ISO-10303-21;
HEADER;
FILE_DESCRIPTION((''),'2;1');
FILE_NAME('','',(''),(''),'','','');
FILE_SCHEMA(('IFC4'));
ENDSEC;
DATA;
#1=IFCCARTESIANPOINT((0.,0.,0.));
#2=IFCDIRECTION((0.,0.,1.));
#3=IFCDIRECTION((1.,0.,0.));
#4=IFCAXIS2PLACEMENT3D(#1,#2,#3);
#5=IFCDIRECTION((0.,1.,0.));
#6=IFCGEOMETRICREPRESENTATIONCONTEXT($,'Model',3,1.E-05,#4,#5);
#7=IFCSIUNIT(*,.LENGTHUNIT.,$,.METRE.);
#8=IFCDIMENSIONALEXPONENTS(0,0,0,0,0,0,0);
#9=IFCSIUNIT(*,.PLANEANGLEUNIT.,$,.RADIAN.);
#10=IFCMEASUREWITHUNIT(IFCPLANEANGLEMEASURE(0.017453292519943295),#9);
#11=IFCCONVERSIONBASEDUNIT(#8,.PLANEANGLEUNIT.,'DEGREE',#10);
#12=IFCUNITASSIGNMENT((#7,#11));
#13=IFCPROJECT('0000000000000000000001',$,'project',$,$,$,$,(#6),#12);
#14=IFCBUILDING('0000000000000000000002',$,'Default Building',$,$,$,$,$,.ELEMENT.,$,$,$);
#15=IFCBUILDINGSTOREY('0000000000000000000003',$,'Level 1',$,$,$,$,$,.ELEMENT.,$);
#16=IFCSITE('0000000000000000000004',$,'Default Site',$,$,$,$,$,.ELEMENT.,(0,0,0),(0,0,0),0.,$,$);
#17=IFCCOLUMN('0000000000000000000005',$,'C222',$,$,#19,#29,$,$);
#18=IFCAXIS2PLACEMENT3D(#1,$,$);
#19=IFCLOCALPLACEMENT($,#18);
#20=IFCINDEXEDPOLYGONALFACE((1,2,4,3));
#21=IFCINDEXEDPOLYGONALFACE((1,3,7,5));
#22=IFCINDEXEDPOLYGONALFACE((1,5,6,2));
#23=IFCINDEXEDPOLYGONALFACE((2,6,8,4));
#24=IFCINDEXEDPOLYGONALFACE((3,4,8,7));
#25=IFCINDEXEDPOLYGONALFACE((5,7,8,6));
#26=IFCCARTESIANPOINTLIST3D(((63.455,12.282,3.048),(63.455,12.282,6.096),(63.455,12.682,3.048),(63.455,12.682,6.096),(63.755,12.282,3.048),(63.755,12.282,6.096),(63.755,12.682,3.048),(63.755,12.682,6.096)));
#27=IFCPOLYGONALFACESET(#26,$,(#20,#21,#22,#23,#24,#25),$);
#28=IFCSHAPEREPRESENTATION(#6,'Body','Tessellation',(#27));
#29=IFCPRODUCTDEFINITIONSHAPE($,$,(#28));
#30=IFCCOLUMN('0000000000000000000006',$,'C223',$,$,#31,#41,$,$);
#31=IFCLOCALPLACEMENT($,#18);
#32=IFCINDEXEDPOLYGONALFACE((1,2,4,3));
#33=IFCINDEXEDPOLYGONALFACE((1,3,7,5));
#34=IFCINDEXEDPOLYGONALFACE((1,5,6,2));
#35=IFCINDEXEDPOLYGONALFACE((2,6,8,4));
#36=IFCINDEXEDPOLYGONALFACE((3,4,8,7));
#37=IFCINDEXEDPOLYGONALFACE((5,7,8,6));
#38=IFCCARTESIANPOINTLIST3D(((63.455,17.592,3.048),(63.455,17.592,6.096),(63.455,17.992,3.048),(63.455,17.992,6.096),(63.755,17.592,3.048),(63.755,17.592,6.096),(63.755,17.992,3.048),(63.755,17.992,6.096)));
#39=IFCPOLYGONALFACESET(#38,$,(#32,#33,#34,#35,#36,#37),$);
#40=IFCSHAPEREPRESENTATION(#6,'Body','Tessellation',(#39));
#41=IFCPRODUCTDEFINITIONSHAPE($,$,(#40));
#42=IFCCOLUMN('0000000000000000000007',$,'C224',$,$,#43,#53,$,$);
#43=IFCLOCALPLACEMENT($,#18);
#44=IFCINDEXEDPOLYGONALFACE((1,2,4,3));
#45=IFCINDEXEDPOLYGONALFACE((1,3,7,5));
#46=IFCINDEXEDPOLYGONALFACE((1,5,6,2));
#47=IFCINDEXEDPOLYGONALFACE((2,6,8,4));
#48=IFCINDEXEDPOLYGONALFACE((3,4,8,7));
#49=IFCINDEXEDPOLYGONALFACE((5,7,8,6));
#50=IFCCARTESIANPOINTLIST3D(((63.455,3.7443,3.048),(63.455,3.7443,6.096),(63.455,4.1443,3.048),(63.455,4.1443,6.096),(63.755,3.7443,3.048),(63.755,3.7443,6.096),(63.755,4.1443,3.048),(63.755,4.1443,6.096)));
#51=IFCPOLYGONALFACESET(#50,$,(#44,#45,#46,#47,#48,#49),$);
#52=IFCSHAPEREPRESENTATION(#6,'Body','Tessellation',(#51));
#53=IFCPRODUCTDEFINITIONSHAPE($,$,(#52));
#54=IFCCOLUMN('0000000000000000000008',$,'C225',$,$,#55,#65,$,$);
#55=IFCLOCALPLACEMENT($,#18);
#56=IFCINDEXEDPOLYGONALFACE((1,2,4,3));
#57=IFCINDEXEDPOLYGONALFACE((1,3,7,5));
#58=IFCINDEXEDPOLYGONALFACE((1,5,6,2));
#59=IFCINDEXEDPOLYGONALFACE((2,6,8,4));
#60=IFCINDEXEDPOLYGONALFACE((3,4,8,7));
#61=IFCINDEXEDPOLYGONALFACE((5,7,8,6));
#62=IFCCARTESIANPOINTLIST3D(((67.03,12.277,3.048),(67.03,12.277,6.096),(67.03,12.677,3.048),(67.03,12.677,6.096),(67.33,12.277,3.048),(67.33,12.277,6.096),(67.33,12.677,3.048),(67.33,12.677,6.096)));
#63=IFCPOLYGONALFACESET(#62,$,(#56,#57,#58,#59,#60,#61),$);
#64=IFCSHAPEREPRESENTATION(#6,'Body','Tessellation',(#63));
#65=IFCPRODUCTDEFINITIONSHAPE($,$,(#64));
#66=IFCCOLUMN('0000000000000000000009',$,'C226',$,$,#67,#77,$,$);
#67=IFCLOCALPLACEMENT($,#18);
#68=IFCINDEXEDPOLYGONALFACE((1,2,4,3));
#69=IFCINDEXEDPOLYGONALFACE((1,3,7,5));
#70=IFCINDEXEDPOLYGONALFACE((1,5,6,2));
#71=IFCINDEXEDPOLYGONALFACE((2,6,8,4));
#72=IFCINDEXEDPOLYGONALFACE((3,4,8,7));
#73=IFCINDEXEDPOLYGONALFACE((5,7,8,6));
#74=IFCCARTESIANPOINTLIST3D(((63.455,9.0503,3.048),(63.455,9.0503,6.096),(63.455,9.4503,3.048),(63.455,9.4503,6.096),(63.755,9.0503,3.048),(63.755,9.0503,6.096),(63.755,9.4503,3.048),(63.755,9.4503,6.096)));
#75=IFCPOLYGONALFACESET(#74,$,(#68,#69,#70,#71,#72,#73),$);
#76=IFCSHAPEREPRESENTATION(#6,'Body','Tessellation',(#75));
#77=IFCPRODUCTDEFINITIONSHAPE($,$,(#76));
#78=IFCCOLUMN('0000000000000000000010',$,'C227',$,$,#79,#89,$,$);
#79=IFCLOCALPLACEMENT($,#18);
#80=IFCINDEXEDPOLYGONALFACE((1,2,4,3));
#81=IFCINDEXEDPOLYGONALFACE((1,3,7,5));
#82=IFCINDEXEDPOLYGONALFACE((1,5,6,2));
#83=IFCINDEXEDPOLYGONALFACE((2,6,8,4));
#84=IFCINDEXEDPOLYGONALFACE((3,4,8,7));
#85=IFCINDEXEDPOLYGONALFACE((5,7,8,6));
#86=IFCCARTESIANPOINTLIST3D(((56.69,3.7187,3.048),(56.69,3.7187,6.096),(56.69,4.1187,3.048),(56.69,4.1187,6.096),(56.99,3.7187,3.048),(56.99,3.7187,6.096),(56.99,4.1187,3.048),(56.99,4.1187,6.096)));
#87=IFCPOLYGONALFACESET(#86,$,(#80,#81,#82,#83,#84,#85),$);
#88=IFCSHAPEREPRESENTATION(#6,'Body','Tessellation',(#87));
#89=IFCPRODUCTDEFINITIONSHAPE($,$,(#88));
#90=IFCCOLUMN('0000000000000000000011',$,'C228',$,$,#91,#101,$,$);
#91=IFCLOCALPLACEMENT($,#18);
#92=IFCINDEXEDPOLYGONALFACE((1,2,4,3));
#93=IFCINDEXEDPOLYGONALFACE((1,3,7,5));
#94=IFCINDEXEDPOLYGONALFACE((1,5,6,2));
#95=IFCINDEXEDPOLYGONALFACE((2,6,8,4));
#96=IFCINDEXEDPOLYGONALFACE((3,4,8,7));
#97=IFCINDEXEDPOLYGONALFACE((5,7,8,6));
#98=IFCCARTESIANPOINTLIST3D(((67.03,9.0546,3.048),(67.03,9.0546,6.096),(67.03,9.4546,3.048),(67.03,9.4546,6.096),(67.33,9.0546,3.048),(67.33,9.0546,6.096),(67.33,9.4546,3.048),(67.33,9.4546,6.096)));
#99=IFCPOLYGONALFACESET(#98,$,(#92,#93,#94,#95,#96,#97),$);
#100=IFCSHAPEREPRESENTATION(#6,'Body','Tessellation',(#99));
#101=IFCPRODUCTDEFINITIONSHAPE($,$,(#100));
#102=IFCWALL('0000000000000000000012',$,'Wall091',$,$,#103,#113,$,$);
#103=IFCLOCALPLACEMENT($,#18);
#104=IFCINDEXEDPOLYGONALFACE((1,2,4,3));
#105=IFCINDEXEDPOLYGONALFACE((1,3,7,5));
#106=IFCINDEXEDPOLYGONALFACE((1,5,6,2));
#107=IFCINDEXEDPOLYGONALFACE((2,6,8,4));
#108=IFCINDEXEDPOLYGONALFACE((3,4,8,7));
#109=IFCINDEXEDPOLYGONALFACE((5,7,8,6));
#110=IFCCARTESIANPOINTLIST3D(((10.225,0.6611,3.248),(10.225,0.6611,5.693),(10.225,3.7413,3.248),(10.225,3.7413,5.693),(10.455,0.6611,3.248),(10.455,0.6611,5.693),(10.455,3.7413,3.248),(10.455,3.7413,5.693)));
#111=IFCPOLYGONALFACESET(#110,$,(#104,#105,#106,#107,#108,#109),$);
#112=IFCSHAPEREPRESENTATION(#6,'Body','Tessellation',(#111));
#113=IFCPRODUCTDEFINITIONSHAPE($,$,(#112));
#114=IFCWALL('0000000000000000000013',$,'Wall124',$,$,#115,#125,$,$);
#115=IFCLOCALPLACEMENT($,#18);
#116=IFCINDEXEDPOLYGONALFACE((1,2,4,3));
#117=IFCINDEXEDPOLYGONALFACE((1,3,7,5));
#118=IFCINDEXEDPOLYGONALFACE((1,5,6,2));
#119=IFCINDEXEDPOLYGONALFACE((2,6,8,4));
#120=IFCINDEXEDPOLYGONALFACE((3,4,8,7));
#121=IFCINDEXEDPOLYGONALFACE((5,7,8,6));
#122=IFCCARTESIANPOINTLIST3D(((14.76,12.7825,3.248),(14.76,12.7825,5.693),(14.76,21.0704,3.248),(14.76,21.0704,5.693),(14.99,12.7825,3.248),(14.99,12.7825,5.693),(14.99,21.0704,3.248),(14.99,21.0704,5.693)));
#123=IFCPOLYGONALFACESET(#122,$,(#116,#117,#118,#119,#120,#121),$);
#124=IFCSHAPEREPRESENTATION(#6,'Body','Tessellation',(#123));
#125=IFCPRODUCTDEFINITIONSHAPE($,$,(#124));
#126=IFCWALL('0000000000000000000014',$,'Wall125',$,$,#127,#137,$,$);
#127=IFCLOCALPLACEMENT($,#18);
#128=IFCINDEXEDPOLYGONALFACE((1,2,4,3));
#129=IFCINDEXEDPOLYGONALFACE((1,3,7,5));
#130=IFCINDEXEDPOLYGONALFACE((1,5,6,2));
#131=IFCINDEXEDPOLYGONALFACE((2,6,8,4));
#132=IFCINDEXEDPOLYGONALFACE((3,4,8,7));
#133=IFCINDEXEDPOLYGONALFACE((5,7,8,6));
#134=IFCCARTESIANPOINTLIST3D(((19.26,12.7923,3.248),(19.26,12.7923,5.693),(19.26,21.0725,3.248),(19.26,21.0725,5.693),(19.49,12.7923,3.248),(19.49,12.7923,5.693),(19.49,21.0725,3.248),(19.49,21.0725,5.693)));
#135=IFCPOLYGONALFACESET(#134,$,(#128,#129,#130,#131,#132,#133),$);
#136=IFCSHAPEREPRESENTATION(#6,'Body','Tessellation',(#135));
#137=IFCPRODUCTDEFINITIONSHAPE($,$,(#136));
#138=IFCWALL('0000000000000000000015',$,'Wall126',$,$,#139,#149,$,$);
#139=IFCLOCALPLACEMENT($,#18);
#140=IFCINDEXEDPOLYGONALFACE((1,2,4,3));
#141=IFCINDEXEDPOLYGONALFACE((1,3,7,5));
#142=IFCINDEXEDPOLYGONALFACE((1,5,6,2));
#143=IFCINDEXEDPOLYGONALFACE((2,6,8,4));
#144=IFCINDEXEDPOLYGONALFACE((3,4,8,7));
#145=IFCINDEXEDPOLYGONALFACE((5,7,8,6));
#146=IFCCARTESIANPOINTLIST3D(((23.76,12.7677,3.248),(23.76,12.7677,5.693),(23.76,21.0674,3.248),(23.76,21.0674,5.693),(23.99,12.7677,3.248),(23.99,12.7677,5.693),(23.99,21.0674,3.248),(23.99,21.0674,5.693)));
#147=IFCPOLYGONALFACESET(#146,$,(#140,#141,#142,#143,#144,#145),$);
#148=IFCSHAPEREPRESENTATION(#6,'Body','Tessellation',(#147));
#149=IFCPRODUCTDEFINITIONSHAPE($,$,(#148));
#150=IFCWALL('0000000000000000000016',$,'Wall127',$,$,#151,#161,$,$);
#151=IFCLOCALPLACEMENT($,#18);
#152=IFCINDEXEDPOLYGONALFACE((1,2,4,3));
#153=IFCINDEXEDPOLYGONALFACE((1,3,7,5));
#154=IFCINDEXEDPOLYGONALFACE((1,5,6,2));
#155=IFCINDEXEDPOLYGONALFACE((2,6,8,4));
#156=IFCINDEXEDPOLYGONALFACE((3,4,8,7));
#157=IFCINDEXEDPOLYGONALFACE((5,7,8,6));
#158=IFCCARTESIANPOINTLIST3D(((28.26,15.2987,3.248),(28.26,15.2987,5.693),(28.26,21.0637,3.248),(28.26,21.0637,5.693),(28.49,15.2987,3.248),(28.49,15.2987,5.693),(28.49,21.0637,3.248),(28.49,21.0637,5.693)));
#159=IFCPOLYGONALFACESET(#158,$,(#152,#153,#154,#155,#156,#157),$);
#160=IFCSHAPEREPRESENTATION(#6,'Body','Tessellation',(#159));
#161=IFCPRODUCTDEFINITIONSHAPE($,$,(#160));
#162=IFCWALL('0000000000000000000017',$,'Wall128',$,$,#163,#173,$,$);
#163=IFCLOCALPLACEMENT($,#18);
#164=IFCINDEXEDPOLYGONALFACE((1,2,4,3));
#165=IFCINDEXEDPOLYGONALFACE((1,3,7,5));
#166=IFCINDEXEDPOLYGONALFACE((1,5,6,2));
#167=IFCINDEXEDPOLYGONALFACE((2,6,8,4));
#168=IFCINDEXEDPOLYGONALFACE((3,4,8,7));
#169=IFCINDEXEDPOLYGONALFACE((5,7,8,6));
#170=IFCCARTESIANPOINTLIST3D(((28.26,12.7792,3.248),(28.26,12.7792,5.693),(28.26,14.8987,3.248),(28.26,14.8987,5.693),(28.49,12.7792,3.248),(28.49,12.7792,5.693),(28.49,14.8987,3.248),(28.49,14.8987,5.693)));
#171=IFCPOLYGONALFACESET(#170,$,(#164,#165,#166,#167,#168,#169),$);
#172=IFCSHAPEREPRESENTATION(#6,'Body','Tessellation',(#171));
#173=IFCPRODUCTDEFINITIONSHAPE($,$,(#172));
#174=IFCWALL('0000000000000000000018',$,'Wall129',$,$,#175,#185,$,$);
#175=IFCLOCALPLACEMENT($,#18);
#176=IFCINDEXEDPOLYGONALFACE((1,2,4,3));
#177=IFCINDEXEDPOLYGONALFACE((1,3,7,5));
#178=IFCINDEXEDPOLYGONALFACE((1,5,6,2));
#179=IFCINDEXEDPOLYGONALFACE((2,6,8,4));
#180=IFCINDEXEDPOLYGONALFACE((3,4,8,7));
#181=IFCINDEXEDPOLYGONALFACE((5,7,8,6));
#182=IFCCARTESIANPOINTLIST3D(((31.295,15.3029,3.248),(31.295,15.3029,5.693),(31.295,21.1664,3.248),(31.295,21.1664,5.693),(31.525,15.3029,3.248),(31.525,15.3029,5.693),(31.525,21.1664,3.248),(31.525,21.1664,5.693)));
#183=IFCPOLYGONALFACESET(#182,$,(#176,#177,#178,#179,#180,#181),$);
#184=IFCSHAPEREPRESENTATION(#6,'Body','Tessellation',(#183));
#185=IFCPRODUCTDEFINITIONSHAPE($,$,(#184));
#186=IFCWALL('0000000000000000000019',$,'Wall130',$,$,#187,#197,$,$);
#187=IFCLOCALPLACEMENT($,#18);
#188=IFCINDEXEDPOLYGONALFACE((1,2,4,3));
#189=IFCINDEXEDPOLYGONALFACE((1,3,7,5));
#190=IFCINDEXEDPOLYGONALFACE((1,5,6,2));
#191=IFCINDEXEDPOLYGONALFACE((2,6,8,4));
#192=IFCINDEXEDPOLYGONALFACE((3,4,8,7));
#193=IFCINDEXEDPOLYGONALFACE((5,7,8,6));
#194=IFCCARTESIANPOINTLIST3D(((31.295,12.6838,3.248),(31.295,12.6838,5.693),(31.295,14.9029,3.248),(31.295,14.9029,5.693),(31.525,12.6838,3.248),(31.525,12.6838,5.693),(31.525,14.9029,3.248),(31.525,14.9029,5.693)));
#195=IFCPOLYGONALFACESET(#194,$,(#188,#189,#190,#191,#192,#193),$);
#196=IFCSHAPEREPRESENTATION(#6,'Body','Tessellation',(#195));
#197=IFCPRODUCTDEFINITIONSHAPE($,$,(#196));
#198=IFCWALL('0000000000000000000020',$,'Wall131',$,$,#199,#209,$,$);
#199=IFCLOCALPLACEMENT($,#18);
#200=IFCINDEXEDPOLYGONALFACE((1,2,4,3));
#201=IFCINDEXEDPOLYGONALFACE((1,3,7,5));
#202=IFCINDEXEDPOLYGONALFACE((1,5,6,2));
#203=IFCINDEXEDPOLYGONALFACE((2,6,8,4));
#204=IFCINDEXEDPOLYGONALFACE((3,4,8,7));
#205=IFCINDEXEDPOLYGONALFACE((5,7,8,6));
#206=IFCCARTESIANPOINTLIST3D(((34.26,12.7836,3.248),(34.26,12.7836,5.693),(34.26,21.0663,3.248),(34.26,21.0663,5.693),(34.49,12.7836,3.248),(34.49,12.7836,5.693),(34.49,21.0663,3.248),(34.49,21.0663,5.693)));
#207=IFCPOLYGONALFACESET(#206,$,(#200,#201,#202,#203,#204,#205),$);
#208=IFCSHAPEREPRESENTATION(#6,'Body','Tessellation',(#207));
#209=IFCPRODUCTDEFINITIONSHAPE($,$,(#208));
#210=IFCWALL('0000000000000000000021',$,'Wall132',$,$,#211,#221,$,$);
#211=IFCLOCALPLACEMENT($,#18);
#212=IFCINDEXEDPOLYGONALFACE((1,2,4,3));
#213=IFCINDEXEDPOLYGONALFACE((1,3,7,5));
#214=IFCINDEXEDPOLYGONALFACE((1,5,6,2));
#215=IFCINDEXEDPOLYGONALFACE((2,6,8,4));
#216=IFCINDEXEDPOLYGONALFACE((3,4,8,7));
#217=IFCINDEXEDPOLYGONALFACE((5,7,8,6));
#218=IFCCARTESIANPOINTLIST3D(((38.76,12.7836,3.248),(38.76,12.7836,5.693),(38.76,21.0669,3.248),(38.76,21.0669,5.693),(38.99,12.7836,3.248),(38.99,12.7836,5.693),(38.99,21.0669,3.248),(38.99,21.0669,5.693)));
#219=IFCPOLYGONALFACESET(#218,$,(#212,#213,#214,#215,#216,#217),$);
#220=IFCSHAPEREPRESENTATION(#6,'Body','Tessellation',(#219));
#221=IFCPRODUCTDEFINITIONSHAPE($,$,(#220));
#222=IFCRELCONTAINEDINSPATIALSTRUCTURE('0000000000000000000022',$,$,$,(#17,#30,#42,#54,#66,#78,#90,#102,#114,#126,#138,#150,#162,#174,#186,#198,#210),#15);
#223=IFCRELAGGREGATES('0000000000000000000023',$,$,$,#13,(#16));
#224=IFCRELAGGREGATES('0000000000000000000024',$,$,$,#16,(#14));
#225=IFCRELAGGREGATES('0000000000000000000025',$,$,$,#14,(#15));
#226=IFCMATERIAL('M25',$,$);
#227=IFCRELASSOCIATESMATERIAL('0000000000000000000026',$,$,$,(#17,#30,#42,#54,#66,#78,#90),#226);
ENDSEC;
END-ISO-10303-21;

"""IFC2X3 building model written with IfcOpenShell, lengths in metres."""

from ifc_helpers import new_model, entity, si_unit, converted_unit, direction, frame, frame_2d, origin_with_axes, place, context, project, spatial, rectangle, extrude, material, element, save


model = new_model("IFC2X3")

# Units and contexts
model_context = context("Model", 3, precision=1e-05, world=origin_with_axes(), true_north=direction((0.0, 1.0, 0.0)))
ifc_project = project(units=[si_unit("LENGTHUNIT", "METRE"), converted_unit("PLANEANGLEUNIT", "DEGREE", entity("IfcPlaneAngleMeasure", 0.017453292519943295), si_unit("PLANEANGLEUNIT", "RADIAN"), dimensions=[0, 0, 0, 0, 0, 0, 0])], contexts=[model_context])

# Site, building, storey
site = spatial("IfcSite", under=ifc_project, Name="Default Site", CompositionType="ELEMENT", RefLatitude=(0, 0, 0), RefLongitude=(0, 0, 0), RefElevation=0.0)
building = spatial("IfcBuilding", under=site, Name="Default Building", CompositionType="ELEMENT")
storey = spatial("IfcBuildingStorey", under=building, Name="Level 1", CompositionType="ELEMENT")

# Columns
ifc_material = material(Name="M25")
placement = place(None, origin_with_axes())
element("IfcColumn", 1, at=placement, inside=storey, material=ifc_material, Name="C222", context=model_context, shape_type="SweptSolid", body=[
    extrude(rectangle(XDim=0.3, YDim=0.4, at=frame_2d((0.0, 0.0), x_axis=(1.0, 0.0, 0.0))), frame((63.605, 12.482, 3.048), z_axis=(0.0, 0.0, 1.0), x_axis=(1.0, 0.0, 0.0)), (0.0, 0.0, 1.0), 3.048),
])
element("IfcColumn", 2, at=placement, inside=storey, material=ifc_material, Name="C223", context=model_context, shape_type="SweptSolid", body=[
    extrude(rectangle(XDim=0.3, YDim=0.4, at=frame_2d((0.0, 0.0), x_axis=(1.0, 0.0, 0.0))), frame((63.605, 17.792, 3.048), z_axis=(0.0, 0.0, 1.0), x_axis=(1.0, 0.0, 0.0)), (0.0, 0.0, 1.0), 3.048),
])
element("IfcColumn", 3, at=placement, inside=storey, material=ifc_material, Name="C224", context=model_context, shape_type="SweptSolid", body=[
    extrude(rectangle(XDim=0.3, YDim=0.4, at=frame_2d((0.0, 0.0), x_axis=(1.0, 0.0, 0.0))), frame((63.605, 3.9443, 3.048), z_axis=(0.0, 0.0, 1.0), x_axis=(1.0, 0.0, 0.0)), (0.0, 0.0, 1.0), 3.048),
])
element("IfcColumn", 4, at=placement, inside=storey, material=ifc_material, Name="C225", context=model_context, shape_type="SweptSolid", body=[
    extrude(rectangle(XDim=0.3, YDim=0.4, at=frame_2d((0.0, 0.0), x_axis=(1.0, 0.0, 0.0))), frame((67.18, 12.477, 3.048), z_axis=(0.0, 0.0, 1.0), x_axis=(1.0, 0.0, 0.0)), (0.0, 0.0, 1.0), 3.048),
])
element("IfcColumn", 5, at=placement, inside=storey, material=ifc_material, Name="C226", context=model_context, shape_type="SweptSolid", body=[
    extrude(rectangle(XDim=0.3, YDim=0.4, at=frame_2d((0.0, 0.0), x_axis=(1.0, 0.0, 0.0))), frame((63.605, 9.2503, 3.048), z_axis=(0.0, 0.0, 1.0), x_axis=(1.0, 0.0, 0.0)), (0.0, 0.0, 1.0), 3.048),
])
element("IfcColumn", 6, at=placement, inside=storey, material=ifc_material, Name="C227", context=model_context, shape_type="SweptSolid", body=[
    extrude(rectangle(XDim=0.3, YDim=0.4, at=frame_2d((0.0, 0.0), x_axis=(1.0, 0.0, 0.0))), frame((56.84, 3.9187, 3.048), z_axis=(0.0, 0.0, 1.0), x_axis=(1.0, 0.0, 0.0)), (0.0, 0.0, 1.0), 3.048),
])
element("IfcColumn", 7, at=placement, inside=storey, material=ifc_material, Name="C228", context=model_context, shape_type="SweptSolid", body=[
    extrude(rectangle(XDim=0.3, YDim=0.4, at=frame_2d((0.0, 0.0), x_axis=(1.0, 0.0, 0.0))), frame((67.18, 9.2546, 3.048), z_axis=(0.0, 0.0, 1.0), x_axis=(1.0, 0.0, 0.0)), (0.0, 0.0, 1.0), 3.048),
])

# Walls
element("IfcWall", 8, at=placement, inside=storey, Name="Wall091", context=model_context, shape_type="SweptSolid", body=[
    extrude(rectangle(XDim=3.0802, YDim=0.23, at=frame_2d((0.0, 0.0), x_axis=(0.0, -1.0, 0.0))), frame((10.34, 2.2012, 3.248), z_axis=(0.0, 0.0, 1.0), x_axis=(1.0, 0.0, 0.0)), (0.0, 0.0, 1.0), 2.445),
])
element("IfcWall", 9, at=placement, inside=storey, Name="Wall124", context=model_context, shape_type="SweptSolid", body=[
    extrude(rectangle(XDim=8.2879, YDim=0.23, at=frame_2d((0.0, 0.0), x_axis=(0.0, -1.0, 0.0))), frame((14.875, 16.9264, 3.248), z_axis=(0.0, 0.0, 1.0), x_axis=(1.0, 0.0, 0.0)), (0.0, 0.0, 1.0), 2.445),
])
element("IfcWall", 10, at=placement, inside=storey, Name="Wall125", context=model_context, shape_type="SweptSolid", body=[
    extrude(rectangle(XDim=8.2802, YDim=0.23, at=frame_2d((0.0, 0.0), x_axis=(0.0, -1.0, 0.0))), frame((19.375, 16.9324, 3.248), z_axis=(0.0, 0.0, 1.0), x_axis=(1.0, 0.0, 0.0)), (0.0, 0.0, 1.0), 2.445),
])
element("IfcWall", 11, at=placement, inside=storey, Name="Wall126", context=model_context, shape_type="SweptSolid", body=[
    extrude(rectangle(XDim=8.2997, YDim=0.23, at=frame_2d((0.0, 0.0), x_axis=(0.0, -1.0, 0.0))), frame((23.875, 16.9175, 3.248), z_axis=(0.0, 0.0, 1.0), x_axis=(1.0, 0.0, 0.0)), (0.0, 0.0, 1.0), 2.445),
])
element("IfcWall", 12, at=placement, inside=storey, Name="Wall127", context=model_context, shape_type="SweptSolid", body=[
    extrude(rectangle(XDim=5.765, YDim=0.23, at=frame_2d((0.0, 0.0), x_axis=(0.0, -1.0, 0.0))), frame((28.375, 18.1812, 3.248), z_axis=(0.0, 0.0, 1.0), x_axis=(1.0, 0.0, 0.0)), (0.0, 0.0, 1.0), 2.445),
])
element("IfcWall", 13, at=placement, inside=storey, Name="Wall128", context=model_context, shape_type="SweptSolid", body=[
    extrude(rectangle(XDim=2.1195, YDim=0.23, at=frame_2d((0.0, 0.0), x_axis=(0.0, 1.0, 0.0))), frame((28.375, 13.8389, 3.248), z_axis=(0.0, 0.0, 1.0), x_axis=(1.0, 0.0, 0.0)), (0.0, 0.0, 1.0), 2.445),
])
element("IfcWall", 14, at=placement, inside=storey, Name="Wall129", context=model_context, shape_type="SweptSolid", body=[
    extrude(rectangle(XDim=5.8635, YDim=0.23, at=frame_2d((0.0, 0.0), x_axis=(0.0, -1.0, 0.0))), frame((31.41, 18.2346, 3.248), z_axis=(0.0, 0.0, 1.0), x_axis=(1.0, 0.0, 0.0)), (0.0, 0.0, 1.0), 2.445),
])
element("IfcWall", 15, at=placement, inside=storey, Name="Wall130", context=model_context, shape_type="SweptSolid", body=[
    extrude(rectangle(XDim=2.2191, YDim=0.23, at=frame_2d((0.0, 0.0), x_axis=(0.0, 1.0, 0.0))), frame((31.41, 13.7934, 3.248), z_axis=(0.0, 0.0, 1.0), x_axis=(1.0, 0.0, 0.0)), (0.0, 0.0, 1.0), 2.445),
])
element("IfcWall", 16, at=placement, inside=storey, Name="Wall131", context=model_context, shape_type="SweptSolid", body=[
    extrude(rectangle(XDim=8.2827, YDim=0.23, at=frame_2d((0.0, 0.0), x_axis=(0.0, -1.0, 0.0))), frame((34.375, 16.925, 3.248), z_axis=(0.0, 0.0, 1.0), x_axis=(1.0, 0.0, 0.0)), (0.0, 0.0, 1.0), 2.445),
])
element("IfcWall", 17, at=placement, inside=storey, Name="Wall132", context=model_context, shape_type="SweptSolid", body=[
    extrude(rectangle(XDim=8.2833, YDim=0.23, at=frame_2d((0.0, 0.0), x_axis=(0.0, -1.0, 0.0))), frame((38.875, 16.9253, 3.248), z_axis=(0.0, 0.0, 1.0), x_axis=(1.0, 0.0, 0.0)), (0.0, 0.0, 1.0), 2.445),
])

save(model, "model.ifc")
